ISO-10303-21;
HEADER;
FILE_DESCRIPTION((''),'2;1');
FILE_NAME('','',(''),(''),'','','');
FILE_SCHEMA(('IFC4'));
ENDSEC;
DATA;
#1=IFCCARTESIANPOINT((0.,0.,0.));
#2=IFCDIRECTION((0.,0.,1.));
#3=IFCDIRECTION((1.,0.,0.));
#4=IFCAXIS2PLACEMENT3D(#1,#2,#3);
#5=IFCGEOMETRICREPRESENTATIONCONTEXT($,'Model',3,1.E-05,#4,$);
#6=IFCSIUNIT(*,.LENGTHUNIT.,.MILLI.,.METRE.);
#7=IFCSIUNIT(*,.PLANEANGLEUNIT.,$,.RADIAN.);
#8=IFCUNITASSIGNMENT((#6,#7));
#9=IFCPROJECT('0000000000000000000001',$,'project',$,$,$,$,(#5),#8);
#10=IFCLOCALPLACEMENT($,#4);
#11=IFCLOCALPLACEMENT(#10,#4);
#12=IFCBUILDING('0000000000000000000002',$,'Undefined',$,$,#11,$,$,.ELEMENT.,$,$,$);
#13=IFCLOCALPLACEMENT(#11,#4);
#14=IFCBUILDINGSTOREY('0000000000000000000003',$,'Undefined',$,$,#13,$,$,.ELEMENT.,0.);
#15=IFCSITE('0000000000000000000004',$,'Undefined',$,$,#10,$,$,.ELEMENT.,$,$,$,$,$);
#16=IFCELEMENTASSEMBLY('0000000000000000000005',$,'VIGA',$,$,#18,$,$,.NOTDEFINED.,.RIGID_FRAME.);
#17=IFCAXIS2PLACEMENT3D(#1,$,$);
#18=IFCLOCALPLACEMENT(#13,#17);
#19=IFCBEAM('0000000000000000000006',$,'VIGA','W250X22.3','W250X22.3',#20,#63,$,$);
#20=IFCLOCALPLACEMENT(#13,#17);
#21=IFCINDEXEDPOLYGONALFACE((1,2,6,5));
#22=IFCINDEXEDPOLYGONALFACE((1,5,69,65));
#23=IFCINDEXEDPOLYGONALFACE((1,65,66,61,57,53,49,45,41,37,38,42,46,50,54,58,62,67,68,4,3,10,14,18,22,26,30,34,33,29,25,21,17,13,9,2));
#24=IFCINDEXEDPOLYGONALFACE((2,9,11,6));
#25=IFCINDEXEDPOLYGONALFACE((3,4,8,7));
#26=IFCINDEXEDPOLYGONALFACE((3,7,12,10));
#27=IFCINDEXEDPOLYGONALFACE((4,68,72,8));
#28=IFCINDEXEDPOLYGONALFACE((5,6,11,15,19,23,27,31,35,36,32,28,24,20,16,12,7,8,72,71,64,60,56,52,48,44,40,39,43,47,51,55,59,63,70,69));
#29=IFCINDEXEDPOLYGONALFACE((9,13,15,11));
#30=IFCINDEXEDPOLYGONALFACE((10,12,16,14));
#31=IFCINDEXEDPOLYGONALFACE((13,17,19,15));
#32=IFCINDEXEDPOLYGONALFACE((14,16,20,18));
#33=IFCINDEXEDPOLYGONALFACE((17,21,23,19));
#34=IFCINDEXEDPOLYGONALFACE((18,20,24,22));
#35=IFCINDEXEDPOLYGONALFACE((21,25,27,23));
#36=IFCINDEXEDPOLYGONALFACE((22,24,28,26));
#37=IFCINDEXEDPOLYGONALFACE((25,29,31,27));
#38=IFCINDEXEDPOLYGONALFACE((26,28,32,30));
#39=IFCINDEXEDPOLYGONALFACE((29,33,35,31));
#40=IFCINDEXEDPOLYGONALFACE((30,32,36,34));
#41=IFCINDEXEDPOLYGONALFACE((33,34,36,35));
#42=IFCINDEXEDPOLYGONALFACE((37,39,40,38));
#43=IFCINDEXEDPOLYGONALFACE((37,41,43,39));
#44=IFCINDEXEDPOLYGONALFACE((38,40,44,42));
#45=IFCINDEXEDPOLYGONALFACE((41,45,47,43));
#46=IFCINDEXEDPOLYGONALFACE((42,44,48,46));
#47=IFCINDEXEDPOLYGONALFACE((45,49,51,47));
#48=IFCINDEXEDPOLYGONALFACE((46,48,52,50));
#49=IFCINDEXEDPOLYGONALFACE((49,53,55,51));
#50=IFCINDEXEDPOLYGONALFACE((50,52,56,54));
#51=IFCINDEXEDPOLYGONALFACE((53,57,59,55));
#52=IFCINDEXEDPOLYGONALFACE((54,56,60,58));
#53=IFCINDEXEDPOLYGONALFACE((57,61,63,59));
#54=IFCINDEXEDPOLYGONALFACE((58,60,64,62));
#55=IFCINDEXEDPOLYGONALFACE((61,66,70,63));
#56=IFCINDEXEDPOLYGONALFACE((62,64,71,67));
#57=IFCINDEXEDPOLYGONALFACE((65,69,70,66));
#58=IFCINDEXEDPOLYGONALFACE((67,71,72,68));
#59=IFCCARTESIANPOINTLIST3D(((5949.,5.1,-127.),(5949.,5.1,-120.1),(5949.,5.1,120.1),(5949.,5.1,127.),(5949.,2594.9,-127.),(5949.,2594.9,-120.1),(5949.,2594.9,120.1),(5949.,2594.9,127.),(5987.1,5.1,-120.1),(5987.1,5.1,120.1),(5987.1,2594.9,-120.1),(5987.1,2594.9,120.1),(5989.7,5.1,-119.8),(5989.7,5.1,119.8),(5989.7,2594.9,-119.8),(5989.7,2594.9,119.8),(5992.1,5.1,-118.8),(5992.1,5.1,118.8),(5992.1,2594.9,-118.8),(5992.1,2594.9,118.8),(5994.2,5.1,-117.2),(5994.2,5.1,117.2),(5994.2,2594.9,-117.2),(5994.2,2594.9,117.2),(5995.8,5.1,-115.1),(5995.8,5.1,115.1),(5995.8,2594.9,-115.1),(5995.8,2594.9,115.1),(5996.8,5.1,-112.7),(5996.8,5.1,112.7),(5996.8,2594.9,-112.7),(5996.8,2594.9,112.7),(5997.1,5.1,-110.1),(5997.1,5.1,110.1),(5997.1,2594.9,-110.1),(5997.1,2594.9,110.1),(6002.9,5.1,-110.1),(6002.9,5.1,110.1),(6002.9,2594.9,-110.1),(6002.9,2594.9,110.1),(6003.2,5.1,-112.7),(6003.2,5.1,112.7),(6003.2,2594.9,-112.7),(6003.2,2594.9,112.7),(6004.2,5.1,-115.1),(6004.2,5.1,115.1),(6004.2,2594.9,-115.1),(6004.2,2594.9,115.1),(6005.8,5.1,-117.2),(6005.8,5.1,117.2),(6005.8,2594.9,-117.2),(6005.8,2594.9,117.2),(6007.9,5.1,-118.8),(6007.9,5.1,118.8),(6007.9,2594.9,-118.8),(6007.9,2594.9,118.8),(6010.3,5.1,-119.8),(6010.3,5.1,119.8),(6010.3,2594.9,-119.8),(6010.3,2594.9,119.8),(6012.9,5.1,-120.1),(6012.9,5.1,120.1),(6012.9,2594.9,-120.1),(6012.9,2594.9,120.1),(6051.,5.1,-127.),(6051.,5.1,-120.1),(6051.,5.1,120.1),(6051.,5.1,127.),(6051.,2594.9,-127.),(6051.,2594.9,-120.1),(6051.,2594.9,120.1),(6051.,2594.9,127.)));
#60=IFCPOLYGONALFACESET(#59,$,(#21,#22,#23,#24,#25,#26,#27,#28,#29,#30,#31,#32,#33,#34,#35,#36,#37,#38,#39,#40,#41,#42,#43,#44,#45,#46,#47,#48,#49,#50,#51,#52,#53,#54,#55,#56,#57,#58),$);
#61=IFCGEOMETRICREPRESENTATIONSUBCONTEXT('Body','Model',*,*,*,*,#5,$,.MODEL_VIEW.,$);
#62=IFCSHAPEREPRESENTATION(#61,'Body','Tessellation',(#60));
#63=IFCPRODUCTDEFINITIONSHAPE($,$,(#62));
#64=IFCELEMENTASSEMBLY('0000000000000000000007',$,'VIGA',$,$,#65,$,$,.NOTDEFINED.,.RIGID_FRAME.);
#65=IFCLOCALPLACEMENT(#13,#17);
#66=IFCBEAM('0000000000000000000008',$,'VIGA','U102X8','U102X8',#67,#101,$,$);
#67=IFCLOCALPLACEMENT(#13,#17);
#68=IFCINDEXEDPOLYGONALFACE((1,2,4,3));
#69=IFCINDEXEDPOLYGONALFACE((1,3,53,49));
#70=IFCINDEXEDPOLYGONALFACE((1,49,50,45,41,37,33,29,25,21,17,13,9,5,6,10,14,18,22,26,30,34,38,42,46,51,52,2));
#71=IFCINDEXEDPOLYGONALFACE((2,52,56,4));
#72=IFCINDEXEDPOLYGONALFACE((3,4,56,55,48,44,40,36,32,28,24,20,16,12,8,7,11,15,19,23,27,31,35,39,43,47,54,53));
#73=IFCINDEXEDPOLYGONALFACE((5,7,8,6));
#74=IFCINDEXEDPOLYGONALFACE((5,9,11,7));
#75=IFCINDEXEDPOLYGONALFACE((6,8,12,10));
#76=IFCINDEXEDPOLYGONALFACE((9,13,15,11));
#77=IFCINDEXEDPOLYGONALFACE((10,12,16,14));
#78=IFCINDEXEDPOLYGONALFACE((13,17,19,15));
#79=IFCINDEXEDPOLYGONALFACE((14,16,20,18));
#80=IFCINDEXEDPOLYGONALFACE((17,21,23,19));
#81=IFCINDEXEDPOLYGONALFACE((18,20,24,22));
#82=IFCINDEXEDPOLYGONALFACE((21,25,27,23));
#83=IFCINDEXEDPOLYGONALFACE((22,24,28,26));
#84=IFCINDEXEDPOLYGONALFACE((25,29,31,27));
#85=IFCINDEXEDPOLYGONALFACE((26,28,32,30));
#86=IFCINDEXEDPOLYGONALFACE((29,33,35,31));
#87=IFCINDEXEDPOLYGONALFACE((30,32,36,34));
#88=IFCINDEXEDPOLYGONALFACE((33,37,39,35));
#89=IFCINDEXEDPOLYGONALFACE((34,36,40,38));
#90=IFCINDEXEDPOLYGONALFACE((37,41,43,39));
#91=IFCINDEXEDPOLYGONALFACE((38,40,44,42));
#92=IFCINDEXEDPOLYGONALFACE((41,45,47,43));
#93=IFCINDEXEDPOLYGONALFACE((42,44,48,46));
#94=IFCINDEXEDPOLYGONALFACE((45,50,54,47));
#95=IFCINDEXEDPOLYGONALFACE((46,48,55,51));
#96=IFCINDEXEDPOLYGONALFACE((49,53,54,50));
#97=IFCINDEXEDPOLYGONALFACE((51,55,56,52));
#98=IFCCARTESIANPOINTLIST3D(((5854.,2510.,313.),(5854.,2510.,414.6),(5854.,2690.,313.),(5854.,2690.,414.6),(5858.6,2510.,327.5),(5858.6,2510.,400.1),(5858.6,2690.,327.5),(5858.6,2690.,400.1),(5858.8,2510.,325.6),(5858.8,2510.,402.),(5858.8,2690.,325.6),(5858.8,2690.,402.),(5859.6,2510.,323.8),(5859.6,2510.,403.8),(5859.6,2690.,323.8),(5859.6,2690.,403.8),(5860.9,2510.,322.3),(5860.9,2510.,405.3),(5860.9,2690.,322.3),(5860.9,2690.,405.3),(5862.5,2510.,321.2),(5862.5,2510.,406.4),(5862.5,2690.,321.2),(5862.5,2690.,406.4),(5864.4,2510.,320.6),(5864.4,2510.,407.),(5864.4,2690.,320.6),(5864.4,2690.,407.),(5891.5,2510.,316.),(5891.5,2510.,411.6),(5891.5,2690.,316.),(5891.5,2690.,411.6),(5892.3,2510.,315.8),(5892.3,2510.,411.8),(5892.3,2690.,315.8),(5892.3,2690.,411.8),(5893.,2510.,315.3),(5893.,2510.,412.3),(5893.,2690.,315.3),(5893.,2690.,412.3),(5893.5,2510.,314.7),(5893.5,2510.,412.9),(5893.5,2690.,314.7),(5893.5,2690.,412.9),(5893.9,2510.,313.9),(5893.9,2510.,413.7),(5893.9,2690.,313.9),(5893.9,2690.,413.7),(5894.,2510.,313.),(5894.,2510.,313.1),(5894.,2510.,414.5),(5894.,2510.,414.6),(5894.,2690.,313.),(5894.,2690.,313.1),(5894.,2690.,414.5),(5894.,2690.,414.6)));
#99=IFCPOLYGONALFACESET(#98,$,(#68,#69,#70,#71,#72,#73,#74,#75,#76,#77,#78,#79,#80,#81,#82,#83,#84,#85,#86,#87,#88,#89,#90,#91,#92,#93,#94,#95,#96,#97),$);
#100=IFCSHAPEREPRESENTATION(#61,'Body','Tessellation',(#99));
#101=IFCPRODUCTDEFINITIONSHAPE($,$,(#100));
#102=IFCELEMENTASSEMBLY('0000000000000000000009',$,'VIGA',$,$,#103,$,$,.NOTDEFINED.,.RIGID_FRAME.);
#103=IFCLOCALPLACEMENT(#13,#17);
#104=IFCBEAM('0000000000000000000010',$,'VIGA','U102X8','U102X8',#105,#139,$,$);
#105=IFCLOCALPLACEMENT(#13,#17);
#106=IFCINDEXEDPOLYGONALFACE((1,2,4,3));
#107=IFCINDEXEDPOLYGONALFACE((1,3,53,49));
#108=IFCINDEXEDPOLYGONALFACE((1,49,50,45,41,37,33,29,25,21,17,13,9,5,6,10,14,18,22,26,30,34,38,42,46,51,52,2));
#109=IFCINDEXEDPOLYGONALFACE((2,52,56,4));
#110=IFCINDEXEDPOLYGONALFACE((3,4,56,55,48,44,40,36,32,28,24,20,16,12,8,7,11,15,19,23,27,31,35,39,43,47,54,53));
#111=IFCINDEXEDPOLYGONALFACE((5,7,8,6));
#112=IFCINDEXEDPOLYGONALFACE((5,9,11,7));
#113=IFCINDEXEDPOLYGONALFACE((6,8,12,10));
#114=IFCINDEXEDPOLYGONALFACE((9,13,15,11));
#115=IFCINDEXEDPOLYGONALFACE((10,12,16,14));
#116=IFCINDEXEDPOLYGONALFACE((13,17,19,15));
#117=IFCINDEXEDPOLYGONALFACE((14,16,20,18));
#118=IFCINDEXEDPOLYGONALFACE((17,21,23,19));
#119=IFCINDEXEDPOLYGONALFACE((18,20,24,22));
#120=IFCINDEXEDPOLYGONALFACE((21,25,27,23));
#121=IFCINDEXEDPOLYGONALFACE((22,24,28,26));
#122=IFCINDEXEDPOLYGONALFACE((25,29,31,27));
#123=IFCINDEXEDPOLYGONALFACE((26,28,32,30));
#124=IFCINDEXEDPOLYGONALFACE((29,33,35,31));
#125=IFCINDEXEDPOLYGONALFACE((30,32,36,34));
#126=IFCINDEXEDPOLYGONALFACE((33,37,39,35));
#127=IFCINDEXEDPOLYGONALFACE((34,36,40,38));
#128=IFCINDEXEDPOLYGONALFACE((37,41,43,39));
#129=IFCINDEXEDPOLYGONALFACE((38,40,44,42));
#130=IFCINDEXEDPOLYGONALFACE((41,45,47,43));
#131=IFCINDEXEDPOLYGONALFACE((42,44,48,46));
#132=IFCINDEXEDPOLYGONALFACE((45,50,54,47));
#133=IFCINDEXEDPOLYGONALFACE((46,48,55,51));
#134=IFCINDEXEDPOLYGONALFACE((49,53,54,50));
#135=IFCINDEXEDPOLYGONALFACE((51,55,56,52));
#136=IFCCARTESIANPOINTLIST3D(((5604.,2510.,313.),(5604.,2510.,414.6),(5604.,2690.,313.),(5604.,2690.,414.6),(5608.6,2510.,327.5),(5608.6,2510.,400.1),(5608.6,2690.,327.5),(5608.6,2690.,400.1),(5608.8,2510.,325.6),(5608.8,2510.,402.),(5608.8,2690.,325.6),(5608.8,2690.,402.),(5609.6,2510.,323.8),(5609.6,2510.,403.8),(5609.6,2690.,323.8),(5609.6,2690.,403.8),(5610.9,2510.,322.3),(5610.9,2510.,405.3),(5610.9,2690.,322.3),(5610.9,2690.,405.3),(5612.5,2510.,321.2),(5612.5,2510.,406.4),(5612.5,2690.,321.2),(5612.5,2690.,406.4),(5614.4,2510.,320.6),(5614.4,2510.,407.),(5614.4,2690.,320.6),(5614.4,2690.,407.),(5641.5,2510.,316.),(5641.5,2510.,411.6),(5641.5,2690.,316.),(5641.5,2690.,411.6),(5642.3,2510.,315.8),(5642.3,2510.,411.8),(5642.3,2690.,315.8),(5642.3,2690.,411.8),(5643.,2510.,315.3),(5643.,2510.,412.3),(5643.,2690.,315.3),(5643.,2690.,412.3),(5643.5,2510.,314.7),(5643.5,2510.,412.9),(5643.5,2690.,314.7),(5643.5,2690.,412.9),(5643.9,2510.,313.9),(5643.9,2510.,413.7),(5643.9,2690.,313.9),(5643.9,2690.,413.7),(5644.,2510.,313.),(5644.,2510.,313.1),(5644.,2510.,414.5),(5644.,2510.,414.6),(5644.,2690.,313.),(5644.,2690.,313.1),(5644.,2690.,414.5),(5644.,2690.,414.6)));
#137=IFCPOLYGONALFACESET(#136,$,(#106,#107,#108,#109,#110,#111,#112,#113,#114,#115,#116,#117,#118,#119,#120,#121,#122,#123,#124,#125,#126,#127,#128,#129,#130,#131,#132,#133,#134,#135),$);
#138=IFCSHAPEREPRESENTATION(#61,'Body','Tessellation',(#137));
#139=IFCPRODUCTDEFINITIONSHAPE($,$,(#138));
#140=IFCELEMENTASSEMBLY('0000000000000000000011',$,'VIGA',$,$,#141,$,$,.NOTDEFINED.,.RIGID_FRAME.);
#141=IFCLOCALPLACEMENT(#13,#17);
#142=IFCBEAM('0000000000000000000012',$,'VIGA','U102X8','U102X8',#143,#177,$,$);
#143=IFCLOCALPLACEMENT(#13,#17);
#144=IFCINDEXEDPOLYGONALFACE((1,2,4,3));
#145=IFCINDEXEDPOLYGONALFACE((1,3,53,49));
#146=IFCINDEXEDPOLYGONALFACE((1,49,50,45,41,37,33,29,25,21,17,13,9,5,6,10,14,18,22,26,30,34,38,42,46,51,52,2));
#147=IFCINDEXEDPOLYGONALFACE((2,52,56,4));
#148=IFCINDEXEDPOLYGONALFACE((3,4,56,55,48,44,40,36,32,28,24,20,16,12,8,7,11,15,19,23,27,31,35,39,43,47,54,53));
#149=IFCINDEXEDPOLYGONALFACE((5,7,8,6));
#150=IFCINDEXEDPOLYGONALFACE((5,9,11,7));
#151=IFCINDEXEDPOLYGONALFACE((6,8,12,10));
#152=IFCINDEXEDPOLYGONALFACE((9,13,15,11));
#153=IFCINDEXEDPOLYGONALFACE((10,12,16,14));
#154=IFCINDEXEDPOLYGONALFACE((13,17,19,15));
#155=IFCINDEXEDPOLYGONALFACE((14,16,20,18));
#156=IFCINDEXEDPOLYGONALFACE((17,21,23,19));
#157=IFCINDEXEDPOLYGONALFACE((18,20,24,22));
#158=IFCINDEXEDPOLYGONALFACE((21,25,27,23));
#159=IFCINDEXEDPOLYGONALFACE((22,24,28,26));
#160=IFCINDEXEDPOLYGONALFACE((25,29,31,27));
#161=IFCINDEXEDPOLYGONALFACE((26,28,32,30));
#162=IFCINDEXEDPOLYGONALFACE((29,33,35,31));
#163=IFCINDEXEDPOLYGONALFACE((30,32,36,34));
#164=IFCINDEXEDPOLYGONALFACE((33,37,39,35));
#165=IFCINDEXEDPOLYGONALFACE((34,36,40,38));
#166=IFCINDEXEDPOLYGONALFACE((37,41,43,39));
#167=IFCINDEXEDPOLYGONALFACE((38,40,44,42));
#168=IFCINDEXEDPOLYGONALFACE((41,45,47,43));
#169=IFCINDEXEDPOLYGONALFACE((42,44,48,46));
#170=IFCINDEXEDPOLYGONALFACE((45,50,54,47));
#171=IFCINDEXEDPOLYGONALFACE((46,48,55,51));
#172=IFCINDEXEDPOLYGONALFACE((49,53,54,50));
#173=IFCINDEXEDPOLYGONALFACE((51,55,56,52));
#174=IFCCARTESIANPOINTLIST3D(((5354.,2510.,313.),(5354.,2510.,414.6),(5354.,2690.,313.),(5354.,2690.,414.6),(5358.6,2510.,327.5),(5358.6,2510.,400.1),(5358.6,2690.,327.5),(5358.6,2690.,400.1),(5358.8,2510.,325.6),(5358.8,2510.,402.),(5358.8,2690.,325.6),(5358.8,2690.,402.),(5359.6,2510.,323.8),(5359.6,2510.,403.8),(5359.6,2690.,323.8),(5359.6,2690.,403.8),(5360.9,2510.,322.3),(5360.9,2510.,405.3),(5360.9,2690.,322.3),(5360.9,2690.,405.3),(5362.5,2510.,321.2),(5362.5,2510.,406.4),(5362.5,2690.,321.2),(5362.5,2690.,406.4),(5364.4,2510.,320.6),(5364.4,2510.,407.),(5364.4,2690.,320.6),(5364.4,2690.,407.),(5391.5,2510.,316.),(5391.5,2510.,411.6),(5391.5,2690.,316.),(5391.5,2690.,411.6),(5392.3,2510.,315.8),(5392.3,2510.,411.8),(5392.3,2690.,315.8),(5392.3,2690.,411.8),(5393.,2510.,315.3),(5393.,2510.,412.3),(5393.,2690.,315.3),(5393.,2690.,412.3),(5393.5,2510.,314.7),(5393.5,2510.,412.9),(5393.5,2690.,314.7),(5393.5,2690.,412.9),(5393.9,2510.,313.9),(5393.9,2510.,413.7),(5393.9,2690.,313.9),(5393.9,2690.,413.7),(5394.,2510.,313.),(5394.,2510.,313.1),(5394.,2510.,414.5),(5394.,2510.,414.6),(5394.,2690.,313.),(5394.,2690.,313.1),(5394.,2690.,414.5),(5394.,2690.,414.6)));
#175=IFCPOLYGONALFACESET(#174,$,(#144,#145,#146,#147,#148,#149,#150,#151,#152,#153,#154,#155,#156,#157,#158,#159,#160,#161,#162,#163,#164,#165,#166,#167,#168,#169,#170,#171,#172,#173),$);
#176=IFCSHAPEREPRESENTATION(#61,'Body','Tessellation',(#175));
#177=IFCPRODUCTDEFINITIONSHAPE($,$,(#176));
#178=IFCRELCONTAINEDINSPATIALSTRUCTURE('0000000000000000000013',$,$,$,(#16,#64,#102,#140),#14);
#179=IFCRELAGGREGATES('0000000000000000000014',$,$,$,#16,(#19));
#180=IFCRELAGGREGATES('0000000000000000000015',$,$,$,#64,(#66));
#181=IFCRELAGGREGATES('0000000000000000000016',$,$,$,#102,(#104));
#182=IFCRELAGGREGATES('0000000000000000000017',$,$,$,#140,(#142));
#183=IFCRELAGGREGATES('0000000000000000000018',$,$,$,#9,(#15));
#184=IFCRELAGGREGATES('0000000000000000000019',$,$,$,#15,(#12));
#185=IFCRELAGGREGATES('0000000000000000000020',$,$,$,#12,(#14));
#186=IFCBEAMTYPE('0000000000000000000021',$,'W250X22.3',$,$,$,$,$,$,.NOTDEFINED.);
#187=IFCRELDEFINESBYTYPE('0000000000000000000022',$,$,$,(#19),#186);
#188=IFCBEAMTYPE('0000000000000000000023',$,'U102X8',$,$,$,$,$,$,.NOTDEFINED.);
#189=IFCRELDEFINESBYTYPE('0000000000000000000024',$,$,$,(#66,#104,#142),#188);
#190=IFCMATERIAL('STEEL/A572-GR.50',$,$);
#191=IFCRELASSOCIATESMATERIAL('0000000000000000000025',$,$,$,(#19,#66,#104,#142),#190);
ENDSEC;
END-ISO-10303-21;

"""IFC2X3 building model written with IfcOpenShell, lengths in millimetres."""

from ifc_helpers import new_model, si_unit, frame, origin_with_axes, origin_2d_with_axis, place, context, subcontext, project, spatial, i_section, u_section, extrude, material, type_object, element, aggregate, save


model = new_model("IFC2X3")

# Units and contexts
model_context = context("Model", 3, precision=1e-05, world=origin_with_axes())
body_context = subcontext(model_context, "Body", "Model", "MODEL_VIEW")
ifc_project = project(units=[si_unit("LENGTHUNIT", "METRE", prefix="MILLI"), si_unit("PLANEANGLEUNIT", "RADIAN")], contexts=[model_context])

# Site, building, storey
site_placement = place(None, origin_with_axes())
site = spatial("IfcSite", under=ifc_project, at=site_placement, Name="Undefined", CompositionType="ELEMENT")
building_placement = place(site_placement, origin_with_axes())
building = spatial("IfcBuilding", under=site, at=building_placement, Name="Undefined", CompositionType="ELEMENT")
storey_placement = place(building_placement, origin_with_axes())
storey = spatial("IfcBuildingStorey", under=building, at=storey_placement, Name="Undefined", CompositionType="ELEMENT", Elevation=0.0)

# Element assemblies, beams
assembly_1_placement = place(storey_placement, origin_with_axes())
assembly_1 = element("IfcElementAssembly", 1, at=assembly_1_placement, inside=storey, Name="VIGA", AssemblyPlace="NOTDEFINED", PredefinedType="RIGID_FRAME")
ifc_material_1 = material(Name="STEEL/A572-GR.50")
beam_type_1 = type_object("IfcBeamType", Name="W250X22.3", PredefinedType="NOTDEFINED")
beam_1_placement = place(assembly_1_placement, frame((6000.0, 5.1, 0.0), z_axis=(0.0, 0.0, 1.0), x_axis=(0.0, 1.0, 0.0)))
beam_1 = element("IfcBeam", 2, at=beam_1_placement, type_object=beam_type_1, material=ifc_material_1, Name="VIGA", Description="W250X22.3", ObjectType="W250X22.3", context=body_context, shape_type="SweptSolid", body=[
    extrude(i_section(OverallWidth=102.0, OverallDepth=254.0, WebThickness=5.8, FlangeThickness=6.9, FilletRadius=10.0, at=origin_2d_with_axis()), frame((2589.8, 0.0, 0.0), z_axis=(-1.0, 0.0, 0.0), x_axis=(0.0, -1.0, 0.0)), (0.0, 0.0, 1.0), 2589.8),
])
aggregate(assembly_1, [beam_1])
assembly_2_placement = place(storey_placement, origin_with_axes())
assembly_2 = element("IfcElementAssembly", 3, at=assembly_2_placement, inside=storey, Name="VIGA", AssemblyPlace="NOTDEFINED", PredefinedType="RIGID_FRAME")
beam_type_2 = type_object("IfcBeamType", Name="U102X8", PredefinedType="NOTDEFINED")
beam_2_placement = place(assembly_2_placement, frame((5874.0, 2510.0, 363.8), z_axis=(0.0, 0.0, 1.0), x_axis=(0.0, 1.0, 0.0)))
beam_2 = element("IfcBeam", 4, at=beam_2_placement, type_object=beam_type_2, material=ifc_material_1, Name="VIGA", Description="U102X8", ObjectType="U102X8", context=body_context, shape_type="SweptSolid", body=[
    extrude(u_section(Depth=101.6, FlangeWidth=40.0, WebThickness=4.6, FlangeThickness=6.0, FilletRadius=7.0, EdgeRadius=3.0, FlangeSlope=0.16839, at=origin_2d_with_axis()), frame((180.0, 0.0, 0.0), z_axis=(-1.0, 0.0, 0.0), x_axis=(0.0, -1.0, 0.0)), (0.0, 0.0, 1.0), 180.0),
])
aggregate(assembly_2, [beam_2])
assembly_3_placement = place(storey_placement, origin_with_axes())
assembly_3 = element("IfcElementAssembly", 5, at=assembly_3_placement, inside=storey, Name="VIGA", AssemblyPlace="NOTDEFINED", PredefinedType="RIGID_FRAME")
beam_3_placement = place(assembly_3_placement, frame((5624.0, 2510.0, 363.8), z_axis=(0.0, 0.0, 1.0), x_axis=(0.0, 1.0, 0.0)))
beam_3 = element("IfcBeam", 6, at=beam_3_placement, type_object=beam_type_2, material=ifc_material_1, Name="VIGA", Description="U102X8", ObjectType="U102X8", context=body_context, shape_type="SweptSolid", body=[
    extrude(u_section(Depth=101.6, FlangeWidth=40.0, WebThickness=4.6, FlangeThickness=6.0, FilletRadius=7.0, EdgeRadius=3.0, FlangeSlope=0.16839, at=origin_2d_with_axis()), frame((180.0, 0.0, 0.0), z_axis=(-1.0, 0.0, 0.0), x_axis=(0.0, -1.0, 0.0)), (0.0, 0.0, 1.0), 180.0),
])
aggregate(assembly_3, [beam_3])
assembly_4_placement = place(storey_placement, origin_with_axes())
assembly_4 = element("IfcElementAssembly", 7, at=assembly_4_placement, inside=storey, Name="VIGA", AssemblyPlace="NOTDEFINED", PredefinedType="RIGID_FRAME")
beam_4_placement = place(assembly_4_placement, frame((5374.0, 2510.0, 363.8), z_axis=(0.0, 0.0, 1.0), x_axis=(0.0, 1.0, 0.0)))
beam_4 = element("IfcBeam", 8, at=beam_4_placement, type_object=beam_type_2, material=ifc_material_1, Name="VIGA", Description="U102X8", ObjectType="U102X8", context=body_context, shape_type="SweptSolid", body=[
    extrude(u_section(Depth=101.6, FlangeWidth=40.0, WebThickness=4.6, FlangeThickness=6.0, FilletRadius=7.0, EdgeRadius=3.0, FlangeSlope=0.16839, at=origin_2d_with_axis()), frame((180.0, 0.0, 0.0), z_axis=(-1.0, 0.0, 0.0), x_axis=(0.0, -1.0, 0.0)), (0.0, 0.0, 1.0), 180.0),
])
aggregate(assembly_4, [beam_4])

save(model, "model.ifc")
